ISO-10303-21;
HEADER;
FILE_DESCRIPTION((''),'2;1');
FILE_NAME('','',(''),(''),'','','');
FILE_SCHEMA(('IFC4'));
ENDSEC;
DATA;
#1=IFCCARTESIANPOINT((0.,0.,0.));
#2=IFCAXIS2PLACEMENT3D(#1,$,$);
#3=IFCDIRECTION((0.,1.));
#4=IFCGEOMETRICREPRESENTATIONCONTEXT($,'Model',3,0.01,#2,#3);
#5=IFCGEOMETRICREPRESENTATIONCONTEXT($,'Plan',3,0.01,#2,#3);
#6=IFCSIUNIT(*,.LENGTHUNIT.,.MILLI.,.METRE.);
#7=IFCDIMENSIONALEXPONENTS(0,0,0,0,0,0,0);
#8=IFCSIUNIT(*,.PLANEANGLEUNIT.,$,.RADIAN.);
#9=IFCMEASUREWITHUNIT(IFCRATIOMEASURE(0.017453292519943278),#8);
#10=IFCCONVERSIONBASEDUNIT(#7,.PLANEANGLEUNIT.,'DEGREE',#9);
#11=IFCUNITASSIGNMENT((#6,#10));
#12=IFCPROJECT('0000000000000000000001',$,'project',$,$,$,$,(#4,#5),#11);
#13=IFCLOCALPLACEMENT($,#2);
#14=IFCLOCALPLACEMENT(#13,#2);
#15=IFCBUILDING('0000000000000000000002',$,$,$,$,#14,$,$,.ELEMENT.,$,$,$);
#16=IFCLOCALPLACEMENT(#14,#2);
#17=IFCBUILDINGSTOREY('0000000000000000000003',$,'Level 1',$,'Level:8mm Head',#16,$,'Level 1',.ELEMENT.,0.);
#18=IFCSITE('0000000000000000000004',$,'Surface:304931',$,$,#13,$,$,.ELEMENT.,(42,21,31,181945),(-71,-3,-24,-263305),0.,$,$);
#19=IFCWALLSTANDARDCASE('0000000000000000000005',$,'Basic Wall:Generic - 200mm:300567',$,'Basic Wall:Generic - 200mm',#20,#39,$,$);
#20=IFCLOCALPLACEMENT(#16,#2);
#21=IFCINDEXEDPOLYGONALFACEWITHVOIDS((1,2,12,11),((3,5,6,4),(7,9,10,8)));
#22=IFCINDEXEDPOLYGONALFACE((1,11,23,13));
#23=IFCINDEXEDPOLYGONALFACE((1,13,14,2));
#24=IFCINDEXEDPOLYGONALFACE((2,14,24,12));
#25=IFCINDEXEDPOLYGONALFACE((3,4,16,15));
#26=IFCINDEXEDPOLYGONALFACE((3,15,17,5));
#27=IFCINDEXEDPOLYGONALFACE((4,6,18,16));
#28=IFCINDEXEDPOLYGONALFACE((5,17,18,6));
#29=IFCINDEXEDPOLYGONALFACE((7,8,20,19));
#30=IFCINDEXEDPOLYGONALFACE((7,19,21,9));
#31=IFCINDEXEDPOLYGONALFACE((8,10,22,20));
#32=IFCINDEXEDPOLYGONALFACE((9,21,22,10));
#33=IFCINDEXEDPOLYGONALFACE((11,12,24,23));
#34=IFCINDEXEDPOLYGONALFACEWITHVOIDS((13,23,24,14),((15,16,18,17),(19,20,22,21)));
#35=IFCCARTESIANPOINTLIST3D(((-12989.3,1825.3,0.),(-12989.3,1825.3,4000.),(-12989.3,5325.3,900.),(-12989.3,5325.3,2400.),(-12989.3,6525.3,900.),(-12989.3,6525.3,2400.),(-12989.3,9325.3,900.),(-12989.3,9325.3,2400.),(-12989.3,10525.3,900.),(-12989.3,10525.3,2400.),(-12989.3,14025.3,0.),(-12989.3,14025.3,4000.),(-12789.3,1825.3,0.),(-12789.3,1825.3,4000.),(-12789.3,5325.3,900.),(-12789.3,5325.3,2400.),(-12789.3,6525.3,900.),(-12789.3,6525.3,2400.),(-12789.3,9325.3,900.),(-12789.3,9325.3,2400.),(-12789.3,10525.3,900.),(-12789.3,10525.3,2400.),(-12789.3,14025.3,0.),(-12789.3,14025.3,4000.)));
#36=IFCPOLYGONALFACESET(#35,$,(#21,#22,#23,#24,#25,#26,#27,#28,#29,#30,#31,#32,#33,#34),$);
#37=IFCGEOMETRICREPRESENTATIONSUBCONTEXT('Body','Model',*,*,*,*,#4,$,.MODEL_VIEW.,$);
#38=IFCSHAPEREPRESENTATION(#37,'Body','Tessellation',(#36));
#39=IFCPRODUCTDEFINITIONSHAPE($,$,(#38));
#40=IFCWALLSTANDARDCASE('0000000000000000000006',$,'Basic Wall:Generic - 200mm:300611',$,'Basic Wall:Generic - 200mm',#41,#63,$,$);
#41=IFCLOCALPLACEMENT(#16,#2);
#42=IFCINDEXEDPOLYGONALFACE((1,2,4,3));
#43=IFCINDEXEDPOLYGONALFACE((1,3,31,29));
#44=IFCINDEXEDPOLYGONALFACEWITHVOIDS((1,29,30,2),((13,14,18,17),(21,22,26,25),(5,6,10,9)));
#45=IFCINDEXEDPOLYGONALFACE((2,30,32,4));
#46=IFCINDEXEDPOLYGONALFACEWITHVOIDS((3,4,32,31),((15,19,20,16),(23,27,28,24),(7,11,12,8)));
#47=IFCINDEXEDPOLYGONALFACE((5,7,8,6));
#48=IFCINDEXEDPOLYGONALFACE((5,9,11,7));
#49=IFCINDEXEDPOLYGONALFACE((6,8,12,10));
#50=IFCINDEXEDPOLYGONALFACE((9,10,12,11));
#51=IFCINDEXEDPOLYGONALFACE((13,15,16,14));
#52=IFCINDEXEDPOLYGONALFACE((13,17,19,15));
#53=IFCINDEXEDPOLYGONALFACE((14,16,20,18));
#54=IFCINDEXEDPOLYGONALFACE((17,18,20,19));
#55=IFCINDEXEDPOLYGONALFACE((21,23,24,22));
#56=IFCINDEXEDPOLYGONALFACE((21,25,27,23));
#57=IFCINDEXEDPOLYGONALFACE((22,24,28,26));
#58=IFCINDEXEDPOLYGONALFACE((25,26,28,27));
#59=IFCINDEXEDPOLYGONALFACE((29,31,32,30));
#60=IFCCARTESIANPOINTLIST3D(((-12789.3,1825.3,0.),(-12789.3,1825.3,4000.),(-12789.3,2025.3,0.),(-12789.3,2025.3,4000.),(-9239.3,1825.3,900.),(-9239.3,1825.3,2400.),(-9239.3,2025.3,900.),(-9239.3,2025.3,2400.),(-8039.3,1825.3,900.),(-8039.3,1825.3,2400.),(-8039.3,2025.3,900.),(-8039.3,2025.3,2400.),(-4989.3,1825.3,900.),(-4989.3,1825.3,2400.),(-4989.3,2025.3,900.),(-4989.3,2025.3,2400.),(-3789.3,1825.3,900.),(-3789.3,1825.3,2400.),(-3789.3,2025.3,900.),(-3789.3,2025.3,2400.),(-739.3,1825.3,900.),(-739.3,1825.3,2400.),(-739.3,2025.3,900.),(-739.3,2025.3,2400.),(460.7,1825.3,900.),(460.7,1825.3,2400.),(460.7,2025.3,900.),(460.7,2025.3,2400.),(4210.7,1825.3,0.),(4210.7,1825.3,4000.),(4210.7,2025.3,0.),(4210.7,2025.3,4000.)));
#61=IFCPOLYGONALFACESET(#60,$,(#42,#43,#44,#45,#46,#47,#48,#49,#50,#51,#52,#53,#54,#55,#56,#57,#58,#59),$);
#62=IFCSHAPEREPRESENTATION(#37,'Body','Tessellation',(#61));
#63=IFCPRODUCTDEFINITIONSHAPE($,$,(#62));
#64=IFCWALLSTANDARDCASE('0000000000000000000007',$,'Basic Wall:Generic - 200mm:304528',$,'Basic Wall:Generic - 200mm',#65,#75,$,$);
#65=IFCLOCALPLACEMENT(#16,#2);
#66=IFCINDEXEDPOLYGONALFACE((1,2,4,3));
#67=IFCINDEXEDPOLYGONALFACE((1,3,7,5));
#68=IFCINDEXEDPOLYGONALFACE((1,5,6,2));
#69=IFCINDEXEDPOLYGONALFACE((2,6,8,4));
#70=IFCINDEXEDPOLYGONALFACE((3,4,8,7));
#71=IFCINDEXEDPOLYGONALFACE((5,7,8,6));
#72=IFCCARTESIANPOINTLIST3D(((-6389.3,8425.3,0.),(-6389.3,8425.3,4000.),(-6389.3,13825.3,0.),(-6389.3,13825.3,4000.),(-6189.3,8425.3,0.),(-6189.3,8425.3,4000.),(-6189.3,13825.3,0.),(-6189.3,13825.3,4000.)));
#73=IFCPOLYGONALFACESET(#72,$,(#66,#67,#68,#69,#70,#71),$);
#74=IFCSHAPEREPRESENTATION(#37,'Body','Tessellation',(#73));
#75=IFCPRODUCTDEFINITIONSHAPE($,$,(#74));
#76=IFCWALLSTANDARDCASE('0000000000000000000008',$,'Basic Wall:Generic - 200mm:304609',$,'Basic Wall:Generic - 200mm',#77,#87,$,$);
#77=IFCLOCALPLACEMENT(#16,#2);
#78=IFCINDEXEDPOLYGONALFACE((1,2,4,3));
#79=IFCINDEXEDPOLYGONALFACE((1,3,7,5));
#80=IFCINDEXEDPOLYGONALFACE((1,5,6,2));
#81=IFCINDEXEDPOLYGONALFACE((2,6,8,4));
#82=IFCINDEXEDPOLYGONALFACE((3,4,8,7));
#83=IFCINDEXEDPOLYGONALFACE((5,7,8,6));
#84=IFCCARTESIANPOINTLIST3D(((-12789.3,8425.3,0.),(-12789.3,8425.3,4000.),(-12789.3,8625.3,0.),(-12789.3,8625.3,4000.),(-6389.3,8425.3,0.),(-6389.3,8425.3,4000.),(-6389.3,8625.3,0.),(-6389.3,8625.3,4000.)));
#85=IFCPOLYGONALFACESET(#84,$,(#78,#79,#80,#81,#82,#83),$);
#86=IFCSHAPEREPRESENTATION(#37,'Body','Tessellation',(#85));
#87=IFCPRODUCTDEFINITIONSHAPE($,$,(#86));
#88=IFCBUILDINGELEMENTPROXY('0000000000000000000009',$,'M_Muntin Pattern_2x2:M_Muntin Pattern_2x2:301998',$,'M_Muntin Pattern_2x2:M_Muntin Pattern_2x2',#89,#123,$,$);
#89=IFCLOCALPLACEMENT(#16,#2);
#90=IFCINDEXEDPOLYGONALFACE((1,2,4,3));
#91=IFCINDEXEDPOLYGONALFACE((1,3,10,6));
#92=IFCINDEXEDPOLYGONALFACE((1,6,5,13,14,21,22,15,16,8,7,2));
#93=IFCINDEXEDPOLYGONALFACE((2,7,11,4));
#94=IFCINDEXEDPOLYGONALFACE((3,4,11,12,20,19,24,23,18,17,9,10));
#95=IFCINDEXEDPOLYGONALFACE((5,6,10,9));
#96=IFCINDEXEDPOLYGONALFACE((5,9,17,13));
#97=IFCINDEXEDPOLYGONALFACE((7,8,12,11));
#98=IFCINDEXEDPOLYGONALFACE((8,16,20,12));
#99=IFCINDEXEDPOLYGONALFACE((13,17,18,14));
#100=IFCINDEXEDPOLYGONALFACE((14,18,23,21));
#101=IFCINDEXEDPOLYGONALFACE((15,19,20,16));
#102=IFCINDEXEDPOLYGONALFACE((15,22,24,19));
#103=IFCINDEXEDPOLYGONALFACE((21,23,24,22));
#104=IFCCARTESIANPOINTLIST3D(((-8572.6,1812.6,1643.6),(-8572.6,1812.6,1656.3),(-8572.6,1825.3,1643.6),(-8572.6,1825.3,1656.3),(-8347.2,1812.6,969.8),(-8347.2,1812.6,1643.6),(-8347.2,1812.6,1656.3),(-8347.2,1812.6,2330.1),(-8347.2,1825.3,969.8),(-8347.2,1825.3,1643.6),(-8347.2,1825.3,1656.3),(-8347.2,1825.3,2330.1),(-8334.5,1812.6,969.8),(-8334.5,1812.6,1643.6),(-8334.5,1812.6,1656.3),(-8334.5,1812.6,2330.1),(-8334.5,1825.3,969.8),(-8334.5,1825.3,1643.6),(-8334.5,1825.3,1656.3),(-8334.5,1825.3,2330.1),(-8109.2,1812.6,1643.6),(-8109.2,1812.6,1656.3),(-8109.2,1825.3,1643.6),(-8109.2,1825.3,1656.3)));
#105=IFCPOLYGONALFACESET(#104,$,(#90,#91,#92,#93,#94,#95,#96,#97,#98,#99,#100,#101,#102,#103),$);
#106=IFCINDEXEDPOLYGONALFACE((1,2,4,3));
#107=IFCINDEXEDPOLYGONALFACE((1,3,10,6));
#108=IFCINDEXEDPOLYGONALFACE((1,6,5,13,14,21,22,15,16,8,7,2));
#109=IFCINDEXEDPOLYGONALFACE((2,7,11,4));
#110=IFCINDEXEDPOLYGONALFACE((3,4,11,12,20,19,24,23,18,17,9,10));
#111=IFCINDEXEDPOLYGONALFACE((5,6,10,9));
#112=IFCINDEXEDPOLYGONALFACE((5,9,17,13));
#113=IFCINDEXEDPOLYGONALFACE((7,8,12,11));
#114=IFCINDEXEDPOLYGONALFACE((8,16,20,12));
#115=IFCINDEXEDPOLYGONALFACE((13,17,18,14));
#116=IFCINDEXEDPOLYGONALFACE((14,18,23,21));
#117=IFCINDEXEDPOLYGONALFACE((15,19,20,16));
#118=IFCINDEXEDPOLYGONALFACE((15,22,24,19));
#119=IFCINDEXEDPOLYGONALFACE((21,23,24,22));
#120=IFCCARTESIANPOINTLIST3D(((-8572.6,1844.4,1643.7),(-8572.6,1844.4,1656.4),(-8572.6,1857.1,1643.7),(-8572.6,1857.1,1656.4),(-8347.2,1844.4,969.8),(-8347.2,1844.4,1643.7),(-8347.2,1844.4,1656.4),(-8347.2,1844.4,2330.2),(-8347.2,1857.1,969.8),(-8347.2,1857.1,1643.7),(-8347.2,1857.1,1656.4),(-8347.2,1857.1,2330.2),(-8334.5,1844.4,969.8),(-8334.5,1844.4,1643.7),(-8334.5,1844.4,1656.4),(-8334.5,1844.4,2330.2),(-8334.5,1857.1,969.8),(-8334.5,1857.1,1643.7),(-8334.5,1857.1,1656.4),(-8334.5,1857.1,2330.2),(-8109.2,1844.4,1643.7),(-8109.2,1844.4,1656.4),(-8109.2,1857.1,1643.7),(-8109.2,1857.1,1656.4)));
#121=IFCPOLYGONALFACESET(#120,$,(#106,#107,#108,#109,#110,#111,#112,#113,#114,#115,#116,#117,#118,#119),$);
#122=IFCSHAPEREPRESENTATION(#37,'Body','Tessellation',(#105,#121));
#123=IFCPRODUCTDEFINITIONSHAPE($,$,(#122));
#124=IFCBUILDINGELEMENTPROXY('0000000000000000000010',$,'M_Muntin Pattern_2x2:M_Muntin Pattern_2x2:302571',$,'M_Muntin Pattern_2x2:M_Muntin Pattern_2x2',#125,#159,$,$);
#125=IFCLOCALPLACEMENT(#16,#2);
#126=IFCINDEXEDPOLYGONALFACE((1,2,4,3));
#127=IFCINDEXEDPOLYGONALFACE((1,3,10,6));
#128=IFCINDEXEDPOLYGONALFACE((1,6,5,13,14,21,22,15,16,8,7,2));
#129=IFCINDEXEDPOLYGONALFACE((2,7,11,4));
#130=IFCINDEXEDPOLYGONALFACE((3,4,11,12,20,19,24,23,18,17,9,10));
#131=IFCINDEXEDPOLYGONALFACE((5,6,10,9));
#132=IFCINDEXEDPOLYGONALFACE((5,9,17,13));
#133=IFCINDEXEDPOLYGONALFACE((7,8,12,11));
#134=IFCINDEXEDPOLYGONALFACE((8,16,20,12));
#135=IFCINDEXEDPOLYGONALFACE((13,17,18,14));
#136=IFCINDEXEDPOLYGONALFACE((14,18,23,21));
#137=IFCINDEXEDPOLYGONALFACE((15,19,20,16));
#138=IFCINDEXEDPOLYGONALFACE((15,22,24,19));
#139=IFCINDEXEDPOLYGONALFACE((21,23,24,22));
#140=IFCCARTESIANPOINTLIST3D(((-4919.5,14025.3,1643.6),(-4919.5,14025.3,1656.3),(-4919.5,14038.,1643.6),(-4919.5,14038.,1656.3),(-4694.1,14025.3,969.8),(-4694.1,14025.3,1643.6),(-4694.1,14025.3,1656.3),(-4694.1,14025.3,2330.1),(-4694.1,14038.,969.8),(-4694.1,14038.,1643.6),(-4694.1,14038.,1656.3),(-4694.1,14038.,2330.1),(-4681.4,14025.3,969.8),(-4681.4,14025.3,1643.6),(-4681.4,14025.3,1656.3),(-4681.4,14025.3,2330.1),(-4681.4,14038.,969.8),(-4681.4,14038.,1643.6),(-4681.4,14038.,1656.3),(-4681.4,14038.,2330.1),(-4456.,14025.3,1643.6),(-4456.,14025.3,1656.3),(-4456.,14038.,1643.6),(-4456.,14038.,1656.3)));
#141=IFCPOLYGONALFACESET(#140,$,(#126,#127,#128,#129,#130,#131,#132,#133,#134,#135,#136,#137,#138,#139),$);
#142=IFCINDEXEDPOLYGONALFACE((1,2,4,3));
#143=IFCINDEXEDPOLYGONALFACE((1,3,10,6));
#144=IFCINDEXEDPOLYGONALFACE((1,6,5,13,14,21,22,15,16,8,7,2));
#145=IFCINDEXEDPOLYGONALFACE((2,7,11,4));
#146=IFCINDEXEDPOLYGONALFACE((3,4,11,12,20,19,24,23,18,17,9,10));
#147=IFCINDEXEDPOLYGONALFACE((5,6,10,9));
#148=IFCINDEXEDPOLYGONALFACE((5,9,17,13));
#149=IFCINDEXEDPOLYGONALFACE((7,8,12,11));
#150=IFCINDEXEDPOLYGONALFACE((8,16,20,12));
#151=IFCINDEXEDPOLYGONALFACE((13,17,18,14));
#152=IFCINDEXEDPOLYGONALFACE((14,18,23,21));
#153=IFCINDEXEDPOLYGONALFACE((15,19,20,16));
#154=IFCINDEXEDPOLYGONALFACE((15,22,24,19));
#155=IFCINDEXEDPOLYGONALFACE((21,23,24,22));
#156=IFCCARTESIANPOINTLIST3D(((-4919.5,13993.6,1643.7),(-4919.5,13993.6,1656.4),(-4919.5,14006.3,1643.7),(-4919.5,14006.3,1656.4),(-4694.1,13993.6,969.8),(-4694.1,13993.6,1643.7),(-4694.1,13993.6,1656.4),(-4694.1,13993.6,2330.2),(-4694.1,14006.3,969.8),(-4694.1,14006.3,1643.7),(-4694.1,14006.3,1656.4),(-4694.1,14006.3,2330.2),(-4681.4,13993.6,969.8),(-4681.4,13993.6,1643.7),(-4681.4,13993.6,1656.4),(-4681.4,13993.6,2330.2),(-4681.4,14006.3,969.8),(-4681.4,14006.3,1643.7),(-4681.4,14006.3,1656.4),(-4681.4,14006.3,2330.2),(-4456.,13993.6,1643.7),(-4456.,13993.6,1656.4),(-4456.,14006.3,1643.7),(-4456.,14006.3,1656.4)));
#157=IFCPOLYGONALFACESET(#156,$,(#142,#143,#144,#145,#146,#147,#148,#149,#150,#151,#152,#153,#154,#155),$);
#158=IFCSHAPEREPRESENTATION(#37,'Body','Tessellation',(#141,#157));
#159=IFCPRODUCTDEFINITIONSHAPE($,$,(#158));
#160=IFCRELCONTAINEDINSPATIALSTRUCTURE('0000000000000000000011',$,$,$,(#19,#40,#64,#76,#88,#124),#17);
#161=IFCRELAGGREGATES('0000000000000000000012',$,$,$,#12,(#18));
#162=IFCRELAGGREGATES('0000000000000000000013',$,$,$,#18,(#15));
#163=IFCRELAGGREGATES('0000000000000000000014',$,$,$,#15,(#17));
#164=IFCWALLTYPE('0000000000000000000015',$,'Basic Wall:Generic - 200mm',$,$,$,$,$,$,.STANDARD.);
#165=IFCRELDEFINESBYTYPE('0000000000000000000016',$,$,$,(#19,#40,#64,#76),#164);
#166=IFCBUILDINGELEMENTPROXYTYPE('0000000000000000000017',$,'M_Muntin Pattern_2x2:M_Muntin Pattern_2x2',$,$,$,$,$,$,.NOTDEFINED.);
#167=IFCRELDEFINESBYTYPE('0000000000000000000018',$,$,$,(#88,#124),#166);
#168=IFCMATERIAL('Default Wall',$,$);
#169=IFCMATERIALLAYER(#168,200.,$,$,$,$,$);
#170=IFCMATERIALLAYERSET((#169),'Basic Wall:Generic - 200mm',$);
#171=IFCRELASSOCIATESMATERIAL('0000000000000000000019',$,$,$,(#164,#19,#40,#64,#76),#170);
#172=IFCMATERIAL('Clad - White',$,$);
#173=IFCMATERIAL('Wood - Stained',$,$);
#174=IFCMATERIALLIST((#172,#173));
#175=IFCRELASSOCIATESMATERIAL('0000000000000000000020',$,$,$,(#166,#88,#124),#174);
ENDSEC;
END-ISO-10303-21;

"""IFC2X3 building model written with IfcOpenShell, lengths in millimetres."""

from ifc_helpers import new_model, entity, si_unit, converted_unit, direction, frame, frame_2d, origin, place, context, subcontext, project, spatial, polyline, rectangle, outline, extrude, source, transform, mapped, material, material_list, layer, layer_set, layer_usage, type_object, type_shapes, element, save


model = new_model("IFC2X3")

# Units and contexts
model_context = context("Model", 3, precision=0.01, world=origin(), true_north=direction((0.0, 1.0)))
plan_context = context("Plan", 3, precision=0.01, world=origin(), true_north=direction((0.0, 1.0)))
body_context = subcontext(model_context, "Body", "Model", "MODEL_VIEW")
ifc_project = project(units=[si_unit("LENGTHUNIT", "METRE", prefix="MILLI"), converted_unit("PLANEANGLEUNIT", "DEGREE", entity("IfcRatioMeasure", 0.017453292519943278), si_unit("PLANEANGLEUNIT", "RADIAN"), dimensions=[0, 0, 0, 0, 0, 0, 0])], contexts=[model_context, plan_context])

# Site, building, storey
site_placement = place(None, origin())
site = spatial("IfcSite", under=ifc_project, at=site_placement, Name="Surface:304931", CompositionType="ELEMENT", RefLatitude=(42, 21, 31, 181945), RefLongitude=(-71, -3, -24, -263305), RefElevation=0.0)
building_placement = place(site_placement, origin())
building = spatial("IfcBuilding", under=site, at=building_placement, CompositionType="ELEMENT")
storey_placement = place(building_placement, origin())
storey = spatial("IfcBuildingStorey", under=building, at=storey_placement, Name="Level 1", ObjectType="Level:8mm Head", LongName="Level 1", CompositionType="ELEMENT", Elevation=0.0)

# Walls, openings
ifc_material_1 = material(Name="Default Wall")
ifc_layer = layer(ifc_material_1, 200.0)
ifc_layer_set = layer_set([ifc_layer], Name="Basic Wall:Generic - 200mm")
ifc_layer_usage = layer_usage(ifc_layer_set, "AXIS2", "NEGATIVE", 100.0)
wall_type = type_object("IfcWallType", Name="Basic Wall:Generic - 200mm", PredefinedType="STANDARD", material=ifc_layer_set)
wall_1_placement = place(storey_placement, frame((-12889.3, 14025.3, 0.0), z_axis=(0.0, 0.0, 1.0), x_axis=(0.0, -1.0, 0.0)))
wall_1 = element("IfcWallStandardCase", 1, at=wall_1_placement, inside=storey, type_object=wall_type, material=ifc_layer_usage, Name="Basic Wall:Generic - 200mm:300567", ObjectType="Basic Wall:Generic - 200mm", context=body_context, shape_type="SweptSolid", body=[
    extrude(rectangle(XDim=12200.0, YDim=200.0, at=frame_2d((6100.0, 0.0), x_axis=(-1.0, 0.0))), origin(), (0.0, 0.0, 1.0), 4000.0),
])
opening_1_placement = place(wall_1_placement, frame((4700.0, 100.0, 900.0)))
element("IfcOpeningElement", 2, at=opening_1_placement, cuts=wall_1, ObjectType="Opening", context=body_context, shape_type="SweptSolid", body=[
    extrude(rectangle(XDim=1500.0, YDim=1200.0, at=frame_2d((750.0, 600.0), x_axis=(-1.0, 0.0))), frame((0.0, 0.0, 0.0), z_axis=(0.0, -1.0, 0.0), x_axis=(0.0, 0.0, 1.0)), (0.0, 0.0, 1.0), 200.0),
])
opening_2_placement = place(wall_1_placement, frame((8700.0, 100.0, 900.0)))
element("IfcOpeningElement", 3, at=opening_2_placement, cuts=wall_1, ObjectType="Opening", context=body_context, shape_type="SweptSolid", body=[
    extrude(rectangle(XDim=1500.0, YDim=1200.0, at=frame_2d((750.0, 600.0), x_axis=(-1.0, 0.0))), frame((0.0, 0.0, 0.0), z_axis=(0.0, -1.0, 0.0), x_axis=(0.0, 0.0, 1.0)), (0.0, 0.0, 1.0), 200.0),
])
wall_2_placement = place(storey_placement, frame((-12789.3, 1925.3, 0.0)))
wall_2 = element("IfcWallStandardCase", 4, at=wall_2_placement, inside=storey, type_object=wall_type, material=ifc_layer_usage, Name="Basic Wall:Generic - 200mm:300611", ObjectType="Basic Wall:Generic - 200mm", context=body_context, shape_type="SweptSolid", body=[
    extrude(rectangle(XDim=17000.0, YDim=200.0, at=frame_2d((8500.0, 0.0), x_axis=(-1.0, 0.0))), origin(), (0.0, 0.0, 1.0), 4000.0),
])
opening_3_placement = place(wall_2_placement, frame((4750.0, 100.0, 900.0)))
element("IfcOpeningElement", 5, at=opening_3_placement, cuts=wall_2, ObjectType="Opening", context=body_context, shape_type="SweptSolid", body=[
    extrude(rectangle(XDim=1500.0, YDim=1200.0, at=frame_2d((750.0, 600.0), x_axis=(-1.0, 0.0))), frame((0.0, 0.0, 0.0), z_axis=(0.0, -1.0, 0.0), x_axis=(0.0, 0.0, 1.0)), (0.0, 0.0, 1.0), 200.0),
])
opening_4_placement = place(wall_2_placement, frame((9000.0, 100.0, 900.0)))
element("IfcOpeningElement", 6, at=opening_4_placement, cuts=wall_2, ObjectType="Opening", context=body_context, shape_type="SweptSolid", body=[
    extrude(rectangle(XDim=1500.0, YDim=1200.0, at=frame_2d((750.0, 600.0), x_axis=(-1.0, 0.0))), frame((0.0, 0.0, 0.0), z_axis=(0.0, -1.0, 0.0), x_axis=(0.0, 0.0, 1.0)), (0.0, 0.0, 1.0), 200.0),
])
opening_5_placement = place(wall_2_placement, frame((13250.0, 100.0, 900.0)))
element("IfcOpeningElement", 7, at=opening_5_placement, cuts=wall_2, ObjectType="Opening", context=body_context, shape_type="SweptSolid", body=[
    extrude(rectangle(XDim=1500.0, YDim=1200.0, at=frame_2d((750.0, 600.0), x_axis=(-1.0, 0.0))), frame((0.0, 0.0, 0.0), z_axis=(0.0, -1.0, 0.0), x_axis=(0.0, 0.0, 1.0)), (0.0, 0.0, 1.0), 200.0),
])

# Walls
wall_3_placement = place(storey_placement, frame((-6289.3, 13825.3, 0.0), z_axis=(0.0, 0.0, 1.0), x_axis=(0.0, -1.0, 0.0)))
element("IfcWallStandardCase", 8, at=wall_3_placement, inside=storey, type_object=wall_type, material=ifc_layer_usage, Name="Basic Wall:Generic - 200mm:304528", ObjectType="Basic Wall:Generic - 200mm", context=body_context, shape_type="SweptSolid", body=[
    extrude(rectangle(XDim=5400.0, YDim=200.0, at=frame_2d((2700.0, 0.0), x_axis=(-1.0, 0.0))), origin(), (0.0, 0.0, 1.0), 4000.0),
])
wall_4_placement = place(storey_placement, frame((-6389.3, 8525.3, 0.0), z_axis=(0.0, 0.0, 1.0), x_axis=(-1.0, 0.0, 0.0)))
element("IfcWallStandardCase", 9, at=wall_4_placement, inside=storey, type_object=wall_type, material=ifc_layer_usage, Name="Basic Wall:Generic - 200mm:304609", ObjectType="Basic Wall:Generic - 200mm", context=body_context, shape_type="SweptSolid", body=[
    extrude(rectangle(XDim=6400.0, YDim=200.0, at=frame_2d((3200.0, 0.0), x_axis=(-1.0, 0.0))), origin(), (0.0, 0.0, 1.0), 4000.0),
])

# Building element proxies
ifc_material_2 = material(Name="Clad - White")
ifc_material_3 = material(Name="Wood - Stained")
ifc_material_list = material_list([ifc_material_2, ifc_material_3])
building_element_proxy_type_1 = type_object("IfcBuildingElementProxyType", Name="M_Muntin Pattern_2x2:M_Muntin Pattern_2x2", PredefinedType="NOTDEFINED", material=ifc_material_list)
shared_shape_1 = source(origin(), body_context, "Body", "SweptSolid", [
    extrude(outline(polyline([(6.4, -6.4), (680.1, -6.4), (680.1, 6.3), (6.4, 6.3), (6.4, 231.7), (-6.3, 231.7), (-6.3, 6.3), (-680.2, 6.3), (-680.2, -6.4), (-6.3, -6.4), (-6.3, -231.7), (6.4, -231.7), (6.4, -6.4)])), frame((0.0, 9.5, 680.1), z_axis=(0.0, 1.0, 0.0), x_axis=(0.0, 0.0, 1.0)), (0.0, 0.0, 1.0), 12.7),
    extrude(outline(polyline([(6.4, -6.4), (680.2, -6.4), (680.2, 6.3), (6.4, 6.3), (6.4, 231.7), (-6.3, 231.7), (-6.3, 6.3), (-680.2, 6.3), (-680.2, -6.4), (-6.3, -6.4), (-6.3, -231.7), (6.4, -231.7), (6.4, -6.4)])), frame((0.0, -22.2, 680.2), z_axis=(0.0, 1.0, 0.0), x_axis=(0.0, 0.0, 1.0)), (0.0, 0.0, 1.0), 12.7),
])
type_shapes(building_element_proxy_type_1, [shared_shape_1])
proxy_placement = place(storey_placement, frame((-8340.9, 1834.8, 969.8), z_axis=(0.0, 0.0, 1.0), x_axis=(-1.0, 0.0, 0.0)))
element("IfcBuildingElementProxy", 10, at=proxy_placement, inside=storey, type_object=building_element_proxy_type_1, material=ifc_material_list, Name="M_Muntin Pattern_2x2:M_Muntin Pattern_2x2:301998", ObjectType="M_Muntin Pattern_2x2:M_Muntin Pattern_2x2", context=body_context, shape_type="MappedRepresentation", body=[
    mapped(shared_shape_1, transform((0.0, 0.0, 0.0), scale=1.0)),
])
for number, where, name in (
    (11, (-4687.7, 14015.8, 969.8), "M_Muntin Pattern_2x2:M_Muntin Pattern_2x2:302571"),
):
    element("IfcBuildingElementProxy", number, at=place(storey_placement, frame(where)), inside=storey, type_object=building_element_proxy_type_1, material=ifc_material_list, Name=name, ObjectType="M_Muntin Pattern_2x2:M_Muntin Pattern_2x2", context=body_context, shape_type="MappedRepresentation", body=[
        mapped(shared_shape_1, transform((0.0, 0.0, 0.0), scale=1.0)),
    ])

save(model, "model.ifc")
